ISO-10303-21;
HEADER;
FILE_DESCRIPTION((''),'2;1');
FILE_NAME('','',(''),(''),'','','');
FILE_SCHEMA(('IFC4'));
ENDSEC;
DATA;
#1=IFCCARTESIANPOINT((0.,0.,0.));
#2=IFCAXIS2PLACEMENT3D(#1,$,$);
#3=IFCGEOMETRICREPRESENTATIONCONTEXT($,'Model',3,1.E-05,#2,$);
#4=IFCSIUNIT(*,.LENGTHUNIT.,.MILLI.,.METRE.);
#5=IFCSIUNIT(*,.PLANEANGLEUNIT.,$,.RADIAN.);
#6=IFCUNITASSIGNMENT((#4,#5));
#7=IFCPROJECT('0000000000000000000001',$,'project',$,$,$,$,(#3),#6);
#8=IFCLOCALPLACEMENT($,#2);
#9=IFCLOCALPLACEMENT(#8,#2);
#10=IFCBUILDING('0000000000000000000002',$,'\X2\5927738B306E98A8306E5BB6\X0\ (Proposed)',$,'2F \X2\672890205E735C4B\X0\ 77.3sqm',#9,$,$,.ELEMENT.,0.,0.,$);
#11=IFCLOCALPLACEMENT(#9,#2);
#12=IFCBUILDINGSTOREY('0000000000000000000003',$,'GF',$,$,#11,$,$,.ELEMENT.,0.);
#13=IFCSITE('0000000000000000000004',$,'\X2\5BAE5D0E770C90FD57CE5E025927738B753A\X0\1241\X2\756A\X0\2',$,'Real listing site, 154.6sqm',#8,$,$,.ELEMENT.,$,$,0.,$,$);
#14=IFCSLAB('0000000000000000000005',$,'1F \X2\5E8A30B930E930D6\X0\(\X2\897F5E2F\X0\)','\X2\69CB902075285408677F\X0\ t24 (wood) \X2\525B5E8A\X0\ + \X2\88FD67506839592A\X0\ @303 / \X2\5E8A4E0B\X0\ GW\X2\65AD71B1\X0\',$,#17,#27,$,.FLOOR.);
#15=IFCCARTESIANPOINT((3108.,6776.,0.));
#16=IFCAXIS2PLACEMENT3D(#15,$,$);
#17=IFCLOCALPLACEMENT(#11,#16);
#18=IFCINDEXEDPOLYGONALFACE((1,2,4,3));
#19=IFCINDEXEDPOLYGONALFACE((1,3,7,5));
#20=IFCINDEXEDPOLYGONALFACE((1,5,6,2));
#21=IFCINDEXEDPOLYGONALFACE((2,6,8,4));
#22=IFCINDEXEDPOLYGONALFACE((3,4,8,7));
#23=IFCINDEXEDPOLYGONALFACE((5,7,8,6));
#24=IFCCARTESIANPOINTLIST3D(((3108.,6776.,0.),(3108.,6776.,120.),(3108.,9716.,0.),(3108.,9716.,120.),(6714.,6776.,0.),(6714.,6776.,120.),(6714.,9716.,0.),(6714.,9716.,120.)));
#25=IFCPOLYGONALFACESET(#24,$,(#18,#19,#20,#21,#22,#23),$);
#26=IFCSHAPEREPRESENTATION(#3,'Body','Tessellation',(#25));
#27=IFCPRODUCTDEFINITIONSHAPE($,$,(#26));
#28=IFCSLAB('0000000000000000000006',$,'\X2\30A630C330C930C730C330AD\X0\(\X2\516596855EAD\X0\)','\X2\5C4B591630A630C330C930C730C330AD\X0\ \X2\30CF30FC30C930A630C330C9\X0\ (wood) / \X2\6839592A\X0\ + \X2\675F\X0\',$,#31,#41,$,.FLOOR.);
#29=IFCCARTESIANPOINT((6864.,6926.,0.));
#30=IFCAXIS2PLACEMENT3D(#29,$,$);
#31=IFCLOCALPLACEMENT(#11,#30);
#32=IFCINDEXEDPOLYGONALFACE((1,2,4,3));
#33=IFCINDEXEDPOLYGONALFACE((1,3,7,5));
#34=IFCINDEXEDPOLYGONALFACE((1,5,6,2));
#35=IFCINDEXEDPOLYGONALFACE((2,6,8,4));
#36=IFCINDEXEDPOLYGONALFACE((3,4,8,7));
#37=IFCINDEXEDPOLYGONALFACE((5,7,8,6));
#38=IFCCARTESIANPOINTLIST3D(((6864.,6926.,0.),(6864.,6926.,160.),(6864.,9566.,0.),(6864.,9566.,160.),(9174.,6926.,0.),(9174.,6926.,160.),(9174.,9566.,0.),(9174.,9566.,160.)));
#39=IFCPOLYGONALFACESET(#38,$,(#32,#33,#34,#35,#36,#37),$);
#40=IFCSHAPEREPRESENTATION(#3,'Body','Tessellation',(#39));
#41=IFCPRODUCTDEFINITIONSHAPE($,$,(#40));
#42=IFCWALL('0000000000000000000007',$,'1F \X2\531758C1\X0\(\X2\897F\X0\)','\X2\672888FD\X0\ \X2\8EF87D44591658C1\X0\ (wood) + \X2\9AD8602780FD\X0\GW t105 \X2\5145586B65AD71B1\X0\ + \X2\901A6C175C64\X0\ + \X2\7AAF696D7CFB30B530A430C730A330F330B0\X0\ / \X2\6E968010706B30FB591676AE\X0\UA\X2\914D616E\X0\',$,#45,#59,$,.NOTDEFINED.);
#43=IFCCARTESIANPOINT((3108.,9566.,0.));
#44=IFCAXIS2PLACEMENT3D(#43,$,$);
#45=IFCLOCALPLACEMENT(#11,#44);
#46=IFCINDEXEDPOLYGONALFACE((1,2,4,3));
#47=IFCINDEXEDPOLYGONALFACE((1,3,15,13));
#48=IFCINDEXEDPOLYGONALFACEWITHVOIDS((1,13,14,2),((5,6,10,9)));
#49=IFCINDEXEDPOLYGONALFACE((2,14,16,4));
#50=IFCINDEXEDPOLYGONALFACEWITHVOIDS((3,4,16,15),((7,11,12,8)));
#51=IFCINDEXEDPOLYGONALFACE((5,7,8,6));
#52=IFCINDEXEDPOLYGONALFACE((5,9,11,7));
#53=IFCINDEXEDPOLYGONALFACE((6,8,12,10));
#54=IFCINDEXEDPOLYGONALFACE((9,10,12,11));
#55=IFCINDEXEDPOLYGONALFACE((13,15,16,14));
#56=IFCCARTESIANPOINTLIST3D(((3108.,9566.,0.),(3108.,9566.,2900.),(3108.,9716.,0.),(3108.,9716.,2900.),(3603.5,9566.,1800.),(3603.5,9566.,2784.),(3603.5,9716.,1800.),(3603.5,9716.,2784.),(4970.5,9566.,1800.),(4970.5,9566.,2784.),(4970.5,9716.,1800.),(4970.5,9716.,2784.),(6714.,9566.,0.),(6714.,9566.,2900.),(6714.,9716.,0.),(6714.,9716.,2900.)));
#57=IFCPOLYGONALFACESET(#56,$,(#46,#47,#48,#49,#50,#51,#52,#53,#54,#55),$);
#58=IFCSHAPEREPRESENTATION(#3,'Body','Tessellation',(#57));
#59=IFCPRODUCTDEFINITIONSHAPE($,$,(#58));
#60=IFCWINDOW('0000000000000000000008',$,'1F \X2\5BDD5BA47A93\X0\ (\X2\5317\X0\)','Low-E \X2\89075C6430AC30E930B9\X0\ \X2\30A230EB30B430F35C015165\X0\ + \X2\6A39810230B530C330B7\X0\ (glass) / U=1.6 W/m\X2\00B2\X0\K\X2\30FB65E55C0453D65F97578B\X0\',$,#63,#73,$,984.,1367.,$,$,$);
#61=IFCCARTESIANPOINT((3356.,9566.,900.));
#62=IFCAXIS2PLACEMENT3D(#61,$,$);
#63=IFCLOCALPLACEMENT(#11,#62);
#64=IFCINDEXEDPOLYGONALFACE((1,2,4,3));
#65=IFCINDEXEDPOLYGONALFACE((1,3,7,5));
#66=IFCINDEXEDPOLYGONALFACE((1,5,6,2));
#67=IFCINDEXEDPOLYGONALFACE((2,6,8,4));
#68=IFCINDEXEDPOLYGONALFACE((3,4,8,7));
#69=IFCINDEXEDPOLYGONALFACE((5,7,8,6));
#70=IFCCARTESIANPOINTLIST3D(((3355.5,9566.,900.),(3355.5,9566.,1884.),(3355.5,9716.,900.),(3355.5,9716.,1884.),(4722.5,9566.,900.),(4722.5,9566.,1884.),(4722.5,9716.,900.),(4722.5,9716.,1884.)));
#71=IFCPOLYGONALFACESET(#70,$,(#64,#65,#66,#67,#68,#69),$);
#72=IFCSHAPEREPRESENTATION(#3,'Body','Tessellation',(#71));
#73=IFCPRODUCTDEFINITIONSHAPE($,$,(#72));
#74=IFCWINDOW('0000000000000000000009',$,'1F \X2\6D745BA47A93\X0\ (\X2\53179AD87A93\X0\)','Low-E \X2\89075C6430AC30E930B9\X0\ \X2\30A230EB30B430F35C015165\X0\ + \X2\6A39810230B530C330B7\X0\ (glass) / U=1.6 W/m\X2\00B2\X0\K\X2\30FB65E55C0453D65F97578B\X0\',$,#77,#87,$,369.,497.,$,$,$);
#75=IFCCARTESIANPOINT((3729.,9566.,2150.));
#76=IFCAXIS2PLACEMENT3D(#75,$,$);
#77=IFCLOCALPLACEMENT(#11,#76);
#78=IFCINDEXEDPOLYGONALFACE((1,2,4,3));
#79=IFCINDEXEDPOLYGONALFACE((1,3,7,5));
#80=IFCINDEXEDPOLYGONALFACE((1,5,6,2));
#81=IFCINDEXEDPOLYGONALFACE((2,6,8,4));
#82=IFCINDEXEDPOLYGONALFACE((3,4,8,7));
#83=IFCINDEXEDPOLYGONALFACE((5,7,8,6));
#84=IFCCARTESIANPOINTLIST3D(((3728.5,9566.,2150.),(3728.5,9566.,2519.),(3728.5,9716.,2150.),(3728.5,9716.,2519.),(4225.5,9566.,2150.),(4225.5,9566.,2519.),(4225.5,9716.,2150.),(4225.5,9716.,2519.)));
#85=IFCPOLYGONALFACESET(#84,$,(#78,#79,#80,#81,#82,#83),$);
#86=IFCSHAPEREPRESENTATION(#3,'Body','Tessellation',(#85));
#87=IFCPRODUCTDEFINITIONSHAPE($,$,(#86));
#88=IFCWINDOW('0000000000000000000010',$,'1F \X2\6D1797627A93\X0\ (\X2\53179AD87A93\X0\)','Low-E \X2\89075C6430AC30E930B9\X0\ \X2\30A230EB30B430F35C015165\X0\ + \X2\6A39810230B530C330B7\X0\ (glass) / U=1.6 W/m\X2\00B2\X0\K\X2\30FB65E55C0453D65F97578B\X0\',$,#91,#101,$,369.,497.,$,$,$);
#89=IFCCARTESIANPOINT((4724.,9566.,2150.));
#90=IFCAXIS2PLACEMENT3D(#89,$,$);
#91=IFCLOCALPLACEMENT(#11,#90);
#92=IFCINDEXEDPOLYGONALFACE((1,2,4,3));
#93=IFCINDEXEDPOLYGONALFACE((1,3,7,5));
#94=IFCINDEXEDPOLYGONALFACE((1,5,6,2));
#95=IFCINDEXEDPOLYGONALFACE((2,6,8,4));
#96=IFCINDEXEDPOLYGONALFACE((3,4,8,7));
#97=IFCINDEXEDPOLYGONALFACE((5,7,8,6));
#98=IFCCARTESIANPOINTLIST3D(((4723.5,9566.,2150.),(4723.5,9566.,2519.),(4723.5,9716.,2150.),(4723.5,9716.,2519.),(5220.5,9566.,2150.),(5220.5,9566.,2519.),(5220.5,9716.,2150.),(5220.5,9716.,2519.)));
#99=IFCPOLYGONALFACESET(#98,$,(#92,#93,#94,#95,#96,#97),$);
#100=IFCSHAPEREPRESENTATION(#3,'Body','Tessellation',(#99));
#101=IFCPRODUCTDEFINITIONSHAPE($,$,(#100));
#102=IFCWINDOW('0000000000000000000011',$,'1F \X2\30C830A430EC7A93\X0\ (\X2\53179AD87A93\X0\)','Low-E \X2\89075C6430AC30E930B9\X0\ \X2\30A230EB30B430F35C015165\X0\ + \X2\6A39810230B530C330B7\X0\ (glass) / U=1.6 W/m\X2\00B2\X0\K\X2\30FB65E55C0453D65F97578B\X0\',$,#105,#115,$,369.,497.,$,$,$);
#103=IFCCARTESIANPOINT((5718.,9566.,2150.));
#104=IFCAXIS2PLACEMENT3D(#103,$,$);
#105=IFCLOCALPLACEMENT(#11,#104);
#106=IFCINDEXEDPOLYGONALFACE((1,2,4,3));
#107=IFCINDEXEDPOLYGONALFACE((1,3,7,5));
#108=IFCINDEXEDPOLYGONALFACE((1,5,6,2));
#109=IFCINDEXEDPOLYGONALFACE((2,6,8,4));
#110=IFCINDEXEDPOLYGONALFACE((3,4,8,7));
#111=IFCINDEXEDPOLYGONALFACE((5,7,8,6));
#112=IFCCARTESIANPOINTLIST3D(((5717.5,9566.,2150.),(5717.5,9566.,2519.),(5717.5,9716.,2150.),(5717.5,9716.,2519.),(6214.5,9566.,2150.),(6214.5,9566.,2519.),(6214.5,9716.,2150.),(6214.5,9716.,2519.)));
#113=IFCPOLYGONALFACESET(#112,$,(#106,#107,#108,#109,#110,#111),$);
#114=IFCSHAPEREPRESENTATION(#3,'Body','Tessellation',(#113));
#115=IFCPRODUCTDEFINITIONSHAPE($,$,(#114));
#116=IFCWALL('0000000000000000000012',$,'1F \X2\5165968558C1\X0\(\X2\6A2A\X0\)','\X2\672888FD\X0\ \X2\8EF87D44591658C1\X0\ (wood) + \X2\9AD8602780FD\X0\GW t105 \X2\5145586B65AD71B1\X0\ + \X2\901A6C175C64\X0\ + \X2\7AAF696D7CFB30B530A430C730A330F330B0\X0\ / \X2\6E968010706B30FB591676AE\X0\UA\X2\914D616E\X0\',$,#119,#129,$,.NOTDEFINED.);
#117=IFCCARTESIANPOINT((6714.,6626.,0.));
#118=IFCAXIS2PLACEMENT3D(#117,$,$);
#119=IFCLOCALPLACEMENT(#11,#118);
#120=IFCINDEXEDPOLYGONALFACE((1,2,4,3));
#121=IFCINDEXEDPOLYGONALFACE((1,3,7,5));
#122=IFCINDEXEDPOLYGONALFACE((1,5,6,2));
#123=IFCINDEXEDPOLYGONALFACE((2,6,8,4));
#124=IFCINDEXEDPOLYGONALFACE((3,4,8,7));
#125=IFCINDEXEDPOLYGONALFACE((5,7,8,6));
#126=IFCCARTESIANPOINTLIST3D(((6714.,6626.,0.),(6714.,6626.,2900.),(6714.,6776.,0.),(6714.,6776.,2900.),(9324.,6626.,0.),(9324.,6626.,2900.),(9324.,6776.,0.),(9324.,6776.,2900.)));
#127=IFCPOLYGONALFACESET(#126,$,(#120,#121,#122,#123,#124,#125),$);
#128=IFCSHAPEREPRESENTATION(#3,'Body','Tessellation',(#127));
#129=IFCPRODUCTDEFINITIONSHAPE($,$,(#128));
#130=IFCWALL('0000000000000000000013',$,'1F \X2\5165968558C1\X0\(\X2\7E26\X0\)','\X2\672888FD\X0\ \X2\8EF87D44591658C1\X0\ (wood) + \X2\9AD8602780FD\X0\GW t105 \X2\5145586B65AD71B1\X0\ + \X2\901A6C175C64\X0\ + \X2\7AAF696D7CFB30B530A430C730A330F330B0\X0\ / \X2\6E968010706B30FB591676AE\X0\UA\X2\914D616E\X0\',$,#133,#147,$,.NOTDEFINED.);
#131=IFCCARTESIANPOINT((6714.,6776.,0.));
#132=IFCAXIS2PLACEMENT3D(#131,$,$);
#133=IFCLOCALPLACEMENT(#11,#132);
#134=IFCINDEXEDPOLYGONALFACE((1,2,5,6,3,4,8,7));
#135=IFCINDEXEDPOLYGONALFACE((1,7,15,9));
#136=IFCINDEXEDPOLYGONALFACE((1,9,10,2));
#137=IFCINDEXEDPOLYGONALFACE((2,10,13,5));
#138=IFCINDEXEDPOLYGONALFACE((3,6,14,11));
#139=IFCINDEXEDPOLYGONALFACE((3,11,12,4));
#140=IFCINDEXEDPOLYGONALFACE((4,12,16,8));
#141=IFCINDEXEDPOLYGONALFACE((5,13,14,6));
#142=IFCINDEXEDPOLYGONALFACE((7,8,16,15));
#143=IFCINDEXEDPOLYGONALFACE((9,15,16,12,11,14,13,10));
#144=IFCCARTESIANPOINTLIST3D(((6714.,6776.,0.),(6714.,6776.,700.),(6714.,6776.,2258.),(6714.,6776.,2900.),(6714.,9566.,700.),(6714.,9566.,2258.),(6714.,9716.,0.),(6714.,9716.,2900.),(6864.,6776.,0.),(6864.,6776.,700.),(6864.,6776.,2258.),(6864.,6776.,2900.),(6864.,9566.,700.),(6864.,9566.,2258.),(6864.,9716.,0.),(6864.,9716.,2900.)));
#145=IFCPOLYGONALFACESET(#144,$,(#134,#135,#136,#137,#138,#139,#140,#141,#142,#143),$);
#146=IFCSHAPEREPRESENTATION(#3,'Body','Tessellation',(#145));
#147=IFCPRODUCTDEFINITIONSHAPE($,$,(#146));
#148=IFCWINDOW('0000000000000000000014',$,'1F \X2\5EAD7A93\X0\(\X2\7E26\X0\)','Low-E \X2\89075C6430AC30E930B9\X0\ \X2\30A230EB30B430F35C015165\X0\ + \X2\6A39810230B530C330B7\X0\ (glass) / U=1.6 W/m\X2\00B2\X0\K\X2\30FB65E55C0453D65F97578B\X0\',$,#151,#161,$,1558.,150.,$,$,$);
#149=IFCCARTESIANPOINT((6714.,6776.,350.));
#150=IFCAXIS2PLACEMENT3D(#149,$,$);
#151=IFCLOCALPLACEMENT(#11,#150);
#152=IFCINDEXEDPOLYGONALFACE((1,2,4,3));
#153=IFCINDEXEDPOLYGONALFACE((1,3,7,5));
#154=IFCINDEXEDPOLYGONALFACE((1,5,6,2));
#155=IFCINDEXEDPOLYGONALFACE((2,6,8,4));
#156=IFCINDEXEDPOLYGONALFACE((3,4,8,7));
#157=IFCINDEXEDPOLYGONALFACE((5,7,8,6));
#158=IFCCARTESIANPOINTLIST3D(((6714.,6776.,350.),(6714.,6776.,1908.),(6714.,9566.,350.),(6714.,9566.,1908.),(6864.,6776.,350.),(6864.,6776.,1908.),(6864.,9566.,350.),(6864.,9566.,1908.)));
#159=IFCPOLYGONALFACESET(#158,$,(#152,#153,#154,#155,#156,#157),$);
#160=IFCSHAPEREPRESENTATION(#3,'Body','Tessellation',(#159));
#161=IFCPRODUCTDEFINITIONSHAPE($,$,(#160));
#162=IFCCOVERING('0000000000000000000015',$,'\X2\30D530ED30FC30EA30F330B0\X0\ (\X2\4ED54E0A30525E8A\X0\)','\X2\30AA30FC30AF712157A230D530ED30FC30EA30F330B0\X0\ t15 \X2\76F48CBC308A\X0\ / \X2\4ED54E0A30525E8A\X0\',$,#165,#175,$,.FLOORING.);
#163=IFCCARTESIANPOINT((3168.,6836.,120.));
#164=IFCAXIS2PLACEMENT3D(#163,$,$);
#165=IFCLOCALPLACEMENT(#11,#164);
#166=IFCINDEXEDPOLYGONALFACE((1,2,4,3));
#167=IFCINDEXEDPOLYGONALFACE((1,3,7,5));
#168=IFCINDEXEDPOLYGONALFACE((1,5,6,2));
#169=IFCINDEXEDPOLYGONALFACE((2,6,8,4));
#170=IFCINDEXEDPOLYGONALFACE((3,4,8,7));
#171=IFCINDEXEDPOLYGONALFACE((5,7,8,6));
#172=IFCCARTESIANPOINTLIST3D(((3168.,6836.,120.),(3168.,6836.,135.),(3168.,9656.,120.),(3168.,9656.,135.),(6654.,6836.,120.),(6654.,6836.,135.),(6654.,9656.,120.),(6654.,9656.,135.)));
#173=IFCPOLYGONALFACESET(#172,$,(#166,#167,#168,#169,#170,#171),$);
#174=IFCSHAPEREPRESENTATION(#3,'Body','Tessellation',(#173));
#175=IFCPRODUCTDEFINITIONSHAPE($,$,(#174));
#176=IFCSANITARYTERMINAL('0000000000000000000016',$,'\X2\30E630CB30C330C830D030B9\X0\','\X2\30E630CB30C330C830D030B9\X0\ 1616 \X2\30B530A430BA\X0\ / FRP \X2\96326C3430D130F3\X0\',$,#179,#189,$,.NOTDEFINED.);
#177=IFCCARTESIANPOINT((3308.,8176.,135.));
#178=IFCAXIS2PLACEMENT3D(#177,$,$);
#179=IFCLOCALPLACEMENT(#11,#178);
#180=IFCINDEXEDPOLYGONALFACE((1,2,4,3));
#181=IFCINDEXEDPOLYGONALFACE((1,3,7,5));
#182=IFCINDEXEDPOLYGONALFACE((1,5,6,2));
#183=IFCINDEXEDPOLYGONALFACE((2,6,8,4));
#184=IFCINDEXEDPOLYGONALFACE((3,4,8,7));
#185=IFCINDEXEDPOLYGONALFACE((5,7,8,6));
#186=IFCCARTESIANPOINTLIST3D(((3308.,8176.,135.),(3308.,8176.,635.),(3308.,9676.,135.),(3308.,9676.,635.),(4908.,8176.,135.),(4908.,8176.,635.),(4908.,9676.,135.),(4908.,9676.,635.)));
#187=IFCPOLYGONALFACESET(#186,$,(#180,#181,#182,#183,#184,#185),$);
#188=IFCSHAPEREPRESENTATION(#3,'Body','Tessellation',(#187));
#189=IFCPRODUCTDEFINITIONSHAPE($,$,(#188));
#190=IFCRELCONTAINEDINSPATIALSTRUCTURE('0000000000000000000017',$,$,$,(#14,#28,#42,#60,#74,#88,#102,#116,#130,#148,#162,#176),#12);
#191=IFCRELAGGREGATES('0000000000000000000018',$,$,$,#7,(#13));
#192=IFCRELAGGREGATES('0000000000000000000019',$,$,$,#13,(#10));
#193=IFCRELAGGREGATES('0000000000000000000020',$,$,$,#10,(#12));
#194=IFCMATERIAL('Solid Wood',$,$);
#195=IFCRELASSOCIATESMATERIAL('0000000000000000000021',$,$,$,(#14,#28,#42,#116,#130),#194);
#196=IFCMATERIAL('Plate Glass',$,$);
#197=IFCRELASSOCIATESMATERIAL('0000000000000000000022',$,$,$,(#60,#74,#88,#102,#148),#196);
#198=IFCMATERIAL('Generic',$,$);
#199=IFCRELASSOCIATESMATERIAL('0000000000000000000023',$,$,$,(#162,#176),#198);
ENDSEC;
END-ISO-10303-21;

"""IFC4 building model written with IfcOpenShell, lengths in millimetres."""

from ifc_helpers import new_model, si_unit, frame, frame_2d, origin, place, context, project, spatial, rectangle, extrude, material, element, fill, save


model = new_model("IFC4")

# Units and contexts
model_context = context("Model", 3, precision=1e-05, world=origin())
ifc_project = project(units=[si_unit("LENGTHUNIT", "METRE", prefix="MILLI"), si_unit("PLANEANGLEUNIT", "RADIAN")], contexts=[model_context])

# Site, building, storey
site_placement = place(None, origin())
site = spatial("IfcSite", under=ifc_project, at=site_placement, Name="宮崎県都城市大王町1241番2", ObjectType="Real listing site, 154.6sqm", CompositionType="ELEMENT", RefElevation=0.0)
building_placement = place(site_placement, origin())
building = spatial("IfcBuilding", under=site, at=building_placement, Name="大王の風の家 (Proposed)", ObjectType="2F 木造平屋 77.3sqm", CompositionType="ELEMENT", ElevationOfRefHeight=0.0, ElevationOfTerrain=0.0)
storey_placement = place(building_placement, origin())
storey = spatial("IfcBuildingStorey", under=building, at=storey_placement, Name="GF", CompositionType="ELEMENT", Elevation=0.0)

# Slabs
ifc_material_1 = material(Name="Solid Wood")
slab_1_placement = place(storey_placement, frame((3108.0, 6776.0, 0.0)))
element("IfcSlab", 1, at=slab_1_placement, inside=storey, material=ifc_material_1, Name="1F 床スラブ(西帯)", Description="構造用合板 t24 (wood) 剛床 + 製材根太 @303 / 床下 GW断熱", PredefinedType="FLOOR", context=model_context, shape_type="SweptSolid", body=[
    extrude(rectangle(XDim=3606.0, YDim=2940.0, at=frame_2d((1803.0, 1470.0))), frame((3108.0, 6776.0, 0.0)), (0.0, 0.0, 1.0), 120.0),
])
slab_2_placement = place(storey_placement, frame((6864.0, 6926.0, 0.0)))
element("IfcSlab", 2, at=slab_2_placement, inside=storey, material=ifc_material_1, Name="ウッドデッキ(入隅庭)", Description="屋外ウッドデッキ ハードウッド (wood) / 根太 + 束", PredefinedType="FLOOR", context=model_context, shape_type="SweptSolid", body=[
    extrude(rectangle(XDim=2310.0, YDim=2640.0, at=frame_2d((1155.0, 1320.0))), frame((6864.0, 6926.0, 0.0)), (0.0, 0.0, 1.0), 160.0),
])

# Wall, openings, windows
wall_1_placement = place(storey_placement, frame((3108.0, 9566.0, 0.0)))
wall_1 = element("IfcWall", 3, at=wall_1_placement, inside=storey, material=ifc_material_1, Name="1F 北壁(西)", Description="木製 軸組外壁 (wood) + 高性能GW t105 充填断熱 + 通気層 + 窯業系サイディング / 準耐火・外皮UA配慮", PredefinedType="NOTDEFINED", context=model_context, shape_type="SweptSolid", body=[
    extrude(rectangle(XDim=3606.0, YDim=150.0, at=frame_2d((1803.0, 75.0))), frame((3108.0, 9566.0, 0.0)), (0.0, 0.0, 1.0), 2900.0),
])
opening_1_placement = place(storey_placement, frame((3356.0, 9566.0, 900.0)))
opening_1 = element("IfcOpeningElement", 4, at=opening_1_placement, cuts=wall_1, PredefinedType="NOTDEFINED", context=model_context, shape_type="SweptSolid", body=[
    extrude(rectangle(XDim=1367.0, YDim=150.0, at=frame_2d((683.0, 75.0))), frame((3356.0, 9566.0, 900.0)), (0.0, 0.0, 1.0), 984.0),
])
opening_2_placement = place(storey_placement, frame((3729.0, 9566.0, 2150.0)))
opening_2 = element("IfcOpeningElement", 5, at=opening_2_placement, cuts=wall_1, PredefinedType="NOTDEFINED", context=model_context, shape_type="SweptSolid", body=[
    extrude(rectangle(XDim=497.0, YDim=150.0, at=frame_2d((248.0, 75.0))), frame((3729.0, 9566.0, 2150.0)), (0.0, 0.0, 1.0), 369.0),
])
opening_3_placement = place(storey_placement, frame((4724.0, 9566.0, 2150.0)))
opening_3 = element("IfcOpeningElement", 6, at=opening_3_placement, cuts=wall_1, PredefinedType="NOTDEFINED", context=model_context, shape_type="SweptSolid", body=[
    extrude(rectangle(XDim=497.0, YDim=150.0, at=frame_2d((248.0, 75.0))), frame((4724.0, 9566.0, 2150.0)), (0.0, 0.0, 1.0), 369.0),
])
opening_4_placement = place(storey_placement, frame((5718.0, 9566.0, 2150.0)))
opening_4 = element("IfcOpeningElement", 7, at=opening_4_placement, cuts=wall_1, PredefinedType="NOTDEFINED", context=model_context, shape_type="SweptSolid", body=[
    extrude(rectangle(XDim=497.0, YDim=150.0, at=frame_2d((248.0, 75.0))), frame((5718.0, 9566.0, 2150.0)), (0.0, 0.0, 1.0), 369.0),
])
ifc_material_2 = material(Name="Plate Glass")
window_1_placement = place(storey_placement, frame((3356.0, 9566.0, 900.0)))
window_1 = element("IfcWindow", 8, at=window_1_placement, inside=storey, material=ifc_material_2, Name="1F 寝室窓 (北)", Description="Low-E 複層ガラス アルゴン封入 + 樹脂サッシ (glass) / U=1.6 W/m²K・日射取得型", OverallHeight=984.0, OverallWidth=1367.0, context=model_context, shape_type="SweptSolid", body=[
    extrude(rectangle(XDim=1367.0, YDim=150.0, at=frame_2d((683.0, 75.0))), frame((3356.0, 9566.0, 900.0)), (0.0, 0.0, 1.0), 984.0),
])
fill(opening_1, window_1)
window_2_placement = place(storey_placement, frame((3729.0, 9566.0, 2150.0)))
window_2 = element("IfcWindow", 9, at=window_2_placement, inside=storey, material=ifc_material_2, Name="1F 浴室窓 (北高窓)", Description="Low-E 複層ガラス アルゴン封入 + 樹脂サッシ (glass) / U=1.6 W/m²K・日射取得型", OverallHeight=369.0, OverallWidth=497.0, context=model_context, shape_type="SweptSolid", body=[
    extrude(rectangle(XDim=497.0, YDim=150.0, at=frame_2d((248.0, 75.0))), frame((3729.0, 9566.0, 2150.0)), (0.0, 0.0, 1.0), 369.0),
])
fill(opening_2, window_2)
window_3_placement = place(storey_placement, frame((4724.0, 9566.0, 2150.0)))
window_3 = element("IfcWindow", 10, at=window_3_placement, inside=storey, material=ifc_material_2, Name="1F 洗面窓 (北高窓)", Description="Low-E 複層ガラス アルゴン封入 + 樹脂サッシ (glass) / U=1.6 W/m²K・日射取得型", OverallHeight=369.0, OverallWidth=497.0, context=model_context, shape_type="SweptSolid", body=[
    extrude(rectangle(XDim=497.0, YDim=150.0, at=frame_2d((248.0, 75.0))), frame((4724.0, 9566.0, 2150.0)), (0.0, 0.0, 1.0), 369.0),
])
fill(opening_3, window_3)
window_4_placement = place(storey_placement, frame((5718.0, 9566.0, 2150.0)))
window_4 = element("IfcWindow", 11, at=window_4_placement, inside=storey, material=ifc_material_2, Name="1F トイレ窓 (北高窓)", Description="Low-E 複層ガラス アルゴン封入 + 樹脂サッシ (glass) / U=1.6 W/m²K・日射取得型", OverallHeight=369.0, OverallWidth=497.0, context=model_context, shape_type="SweptSolid", body=[
    extrude(rectangle(XDim=497.0, YDim=150.0, at=frame_2d((248.0, 75.0))), frame((5718.0, 9566.0, 2150.0)), (0.0, 0.0, 1.0), 369.0),
])
fill(opening_4, window_4)

# Wall
wall_2_placement = place(storey_placement, frame((6714.0, 6626.0, 0.0)))
element("IfcWall", 12, at=wall_2_placement, inside=storey, material=ifc_material_1, Name="1F 入隅壁(横)", Description="木製 軸組外壁 (wood) + 高性能GW t105 充填断熱 + 通気層 + 窯業系サイディング / 準耐火・外皮UA配慮", PredefinedType="NOTDEFINED", context=model_context, shape_type="SweptSolid", body=[
    extrude(rectangle(XDim=2610.0, YDim=150.0, at=frame_2d((1305.0, 75.0))), frame((6714.0, 6626.0, 0.0)), (0.0, 0.0, 1.0), 2900.0),
])

# Wall, opening, window
wall_3_placement = place(storey_placement, frame((6714.0, 6776.0, 0.0)))
wall_3 = element("IfcWall", 13, at=wall_3_placement, inside=storey, material=ifc_material_1, Name="1F 入隅壁(縦)", Description="木製 軸組外壁 (wood) + 高性能GW t105 充填断熱 + 通気層 + 窯業系サイディング / 準耐火・外皮UA配慮", PredefinedType="NOTDEFINED", context=model_context, shape_type="SweptSolid", body=[
    extrude(rectangle(XDim=150.0, YDim=2940.0, at=frame_2d((75.0, 1470.0))), frame((6714.0, 6776.0, 0.0)), (0.0, 0.0, 1.0), 2900.0),
])
opening_5_placement = place(storey_placement, frame((6714.0, 6776.0, 350.0)))
opening_5 = element("IfcOpeningElement", 14, at=opening_5_placement, cuts=wall_3, PredefinedType="NOTDEFINED", context=model_context, shape_type="SweptSolid", body=[
    extrude(rectangle(XDim=150.0, YDim=2790.0, at=frame_2d((75.0, 1395.0))), frame((6714.0, 6776.0, 350.0)), (0.0, 0.0, 1.0), 1558.0),
])
window_5_placement = place(storey_placement, frame((6714.0, 6776.0, 350.0)))
window_5 = element("IfcWindow", 15, at=window_5_placement, inside=storey, material=ifc_material_2, Name="1F 庭窓(縦)", Description="Low-E 複層ガラス アルゴン封入 + 樹脂サッシ (glass) / U=1.6 W/m²K・日射取得型", OverallHeight=1558.0, OverallWidth=150.0, context=model_context, shape_type="SweptSolid", body=[
    extrude(rectangle(XDim=150.0, YDim=2790.0, at=frame_2d((75.0, 1395.0))), frame((6714.0, 6776.0, 350.0)), (0.0, 0.0, 1.0), 1558.0),
])
fill(opening_5, window_5)

# Covering
ifc_material_3 = material(Name="Generic")
covering_placement = place(storey_placement, frame((3168.0, 6836.0, 120.0)))
element("IfcCovering", 16, at=covering_placement, inside=storey, material=ifc_material_3, Name="フローリング (仕上げ床)", Description="オーク無垢フローリング t15 直貼り / 仕上げ床", PredefinedType="FLOORING", context=model_context, shape_type="SweptSolid", body=[
    extrude(rectangle(XDim=3486.0, YDim=2820.0, at=frame_2d((1743.0, 1410.0))), frame((3168.0, 6836.0, 120.0)), (0.0, 0.0, 1.0), 15.0),
])

# Sanitary terminal
sanitary_terminal_1_placement = place(storey_placement, frame((3308.0, 8176.0, 135.0)))
element("IfcSanitaryTerminal", 17, at=sanitary_terminal_1_placement, inside=storey, material=ifc_material_3, Name="ユニットバス", Description="ユニットバス 1616 サイズ / FRP 防水パン", PredefinedType="NOTDEFINED", context=model_context, shape_type="SweptSolid", body=[
    extrude(rectangle(XDim=1600.0, YDim=1500.0, at=frame_2d((800.0, 750.0))), frame((3308.0, 8176.0, 135.0)), (0.0, 0.0, 1.0), 500.0),
])

save(model, "model.ifc")
